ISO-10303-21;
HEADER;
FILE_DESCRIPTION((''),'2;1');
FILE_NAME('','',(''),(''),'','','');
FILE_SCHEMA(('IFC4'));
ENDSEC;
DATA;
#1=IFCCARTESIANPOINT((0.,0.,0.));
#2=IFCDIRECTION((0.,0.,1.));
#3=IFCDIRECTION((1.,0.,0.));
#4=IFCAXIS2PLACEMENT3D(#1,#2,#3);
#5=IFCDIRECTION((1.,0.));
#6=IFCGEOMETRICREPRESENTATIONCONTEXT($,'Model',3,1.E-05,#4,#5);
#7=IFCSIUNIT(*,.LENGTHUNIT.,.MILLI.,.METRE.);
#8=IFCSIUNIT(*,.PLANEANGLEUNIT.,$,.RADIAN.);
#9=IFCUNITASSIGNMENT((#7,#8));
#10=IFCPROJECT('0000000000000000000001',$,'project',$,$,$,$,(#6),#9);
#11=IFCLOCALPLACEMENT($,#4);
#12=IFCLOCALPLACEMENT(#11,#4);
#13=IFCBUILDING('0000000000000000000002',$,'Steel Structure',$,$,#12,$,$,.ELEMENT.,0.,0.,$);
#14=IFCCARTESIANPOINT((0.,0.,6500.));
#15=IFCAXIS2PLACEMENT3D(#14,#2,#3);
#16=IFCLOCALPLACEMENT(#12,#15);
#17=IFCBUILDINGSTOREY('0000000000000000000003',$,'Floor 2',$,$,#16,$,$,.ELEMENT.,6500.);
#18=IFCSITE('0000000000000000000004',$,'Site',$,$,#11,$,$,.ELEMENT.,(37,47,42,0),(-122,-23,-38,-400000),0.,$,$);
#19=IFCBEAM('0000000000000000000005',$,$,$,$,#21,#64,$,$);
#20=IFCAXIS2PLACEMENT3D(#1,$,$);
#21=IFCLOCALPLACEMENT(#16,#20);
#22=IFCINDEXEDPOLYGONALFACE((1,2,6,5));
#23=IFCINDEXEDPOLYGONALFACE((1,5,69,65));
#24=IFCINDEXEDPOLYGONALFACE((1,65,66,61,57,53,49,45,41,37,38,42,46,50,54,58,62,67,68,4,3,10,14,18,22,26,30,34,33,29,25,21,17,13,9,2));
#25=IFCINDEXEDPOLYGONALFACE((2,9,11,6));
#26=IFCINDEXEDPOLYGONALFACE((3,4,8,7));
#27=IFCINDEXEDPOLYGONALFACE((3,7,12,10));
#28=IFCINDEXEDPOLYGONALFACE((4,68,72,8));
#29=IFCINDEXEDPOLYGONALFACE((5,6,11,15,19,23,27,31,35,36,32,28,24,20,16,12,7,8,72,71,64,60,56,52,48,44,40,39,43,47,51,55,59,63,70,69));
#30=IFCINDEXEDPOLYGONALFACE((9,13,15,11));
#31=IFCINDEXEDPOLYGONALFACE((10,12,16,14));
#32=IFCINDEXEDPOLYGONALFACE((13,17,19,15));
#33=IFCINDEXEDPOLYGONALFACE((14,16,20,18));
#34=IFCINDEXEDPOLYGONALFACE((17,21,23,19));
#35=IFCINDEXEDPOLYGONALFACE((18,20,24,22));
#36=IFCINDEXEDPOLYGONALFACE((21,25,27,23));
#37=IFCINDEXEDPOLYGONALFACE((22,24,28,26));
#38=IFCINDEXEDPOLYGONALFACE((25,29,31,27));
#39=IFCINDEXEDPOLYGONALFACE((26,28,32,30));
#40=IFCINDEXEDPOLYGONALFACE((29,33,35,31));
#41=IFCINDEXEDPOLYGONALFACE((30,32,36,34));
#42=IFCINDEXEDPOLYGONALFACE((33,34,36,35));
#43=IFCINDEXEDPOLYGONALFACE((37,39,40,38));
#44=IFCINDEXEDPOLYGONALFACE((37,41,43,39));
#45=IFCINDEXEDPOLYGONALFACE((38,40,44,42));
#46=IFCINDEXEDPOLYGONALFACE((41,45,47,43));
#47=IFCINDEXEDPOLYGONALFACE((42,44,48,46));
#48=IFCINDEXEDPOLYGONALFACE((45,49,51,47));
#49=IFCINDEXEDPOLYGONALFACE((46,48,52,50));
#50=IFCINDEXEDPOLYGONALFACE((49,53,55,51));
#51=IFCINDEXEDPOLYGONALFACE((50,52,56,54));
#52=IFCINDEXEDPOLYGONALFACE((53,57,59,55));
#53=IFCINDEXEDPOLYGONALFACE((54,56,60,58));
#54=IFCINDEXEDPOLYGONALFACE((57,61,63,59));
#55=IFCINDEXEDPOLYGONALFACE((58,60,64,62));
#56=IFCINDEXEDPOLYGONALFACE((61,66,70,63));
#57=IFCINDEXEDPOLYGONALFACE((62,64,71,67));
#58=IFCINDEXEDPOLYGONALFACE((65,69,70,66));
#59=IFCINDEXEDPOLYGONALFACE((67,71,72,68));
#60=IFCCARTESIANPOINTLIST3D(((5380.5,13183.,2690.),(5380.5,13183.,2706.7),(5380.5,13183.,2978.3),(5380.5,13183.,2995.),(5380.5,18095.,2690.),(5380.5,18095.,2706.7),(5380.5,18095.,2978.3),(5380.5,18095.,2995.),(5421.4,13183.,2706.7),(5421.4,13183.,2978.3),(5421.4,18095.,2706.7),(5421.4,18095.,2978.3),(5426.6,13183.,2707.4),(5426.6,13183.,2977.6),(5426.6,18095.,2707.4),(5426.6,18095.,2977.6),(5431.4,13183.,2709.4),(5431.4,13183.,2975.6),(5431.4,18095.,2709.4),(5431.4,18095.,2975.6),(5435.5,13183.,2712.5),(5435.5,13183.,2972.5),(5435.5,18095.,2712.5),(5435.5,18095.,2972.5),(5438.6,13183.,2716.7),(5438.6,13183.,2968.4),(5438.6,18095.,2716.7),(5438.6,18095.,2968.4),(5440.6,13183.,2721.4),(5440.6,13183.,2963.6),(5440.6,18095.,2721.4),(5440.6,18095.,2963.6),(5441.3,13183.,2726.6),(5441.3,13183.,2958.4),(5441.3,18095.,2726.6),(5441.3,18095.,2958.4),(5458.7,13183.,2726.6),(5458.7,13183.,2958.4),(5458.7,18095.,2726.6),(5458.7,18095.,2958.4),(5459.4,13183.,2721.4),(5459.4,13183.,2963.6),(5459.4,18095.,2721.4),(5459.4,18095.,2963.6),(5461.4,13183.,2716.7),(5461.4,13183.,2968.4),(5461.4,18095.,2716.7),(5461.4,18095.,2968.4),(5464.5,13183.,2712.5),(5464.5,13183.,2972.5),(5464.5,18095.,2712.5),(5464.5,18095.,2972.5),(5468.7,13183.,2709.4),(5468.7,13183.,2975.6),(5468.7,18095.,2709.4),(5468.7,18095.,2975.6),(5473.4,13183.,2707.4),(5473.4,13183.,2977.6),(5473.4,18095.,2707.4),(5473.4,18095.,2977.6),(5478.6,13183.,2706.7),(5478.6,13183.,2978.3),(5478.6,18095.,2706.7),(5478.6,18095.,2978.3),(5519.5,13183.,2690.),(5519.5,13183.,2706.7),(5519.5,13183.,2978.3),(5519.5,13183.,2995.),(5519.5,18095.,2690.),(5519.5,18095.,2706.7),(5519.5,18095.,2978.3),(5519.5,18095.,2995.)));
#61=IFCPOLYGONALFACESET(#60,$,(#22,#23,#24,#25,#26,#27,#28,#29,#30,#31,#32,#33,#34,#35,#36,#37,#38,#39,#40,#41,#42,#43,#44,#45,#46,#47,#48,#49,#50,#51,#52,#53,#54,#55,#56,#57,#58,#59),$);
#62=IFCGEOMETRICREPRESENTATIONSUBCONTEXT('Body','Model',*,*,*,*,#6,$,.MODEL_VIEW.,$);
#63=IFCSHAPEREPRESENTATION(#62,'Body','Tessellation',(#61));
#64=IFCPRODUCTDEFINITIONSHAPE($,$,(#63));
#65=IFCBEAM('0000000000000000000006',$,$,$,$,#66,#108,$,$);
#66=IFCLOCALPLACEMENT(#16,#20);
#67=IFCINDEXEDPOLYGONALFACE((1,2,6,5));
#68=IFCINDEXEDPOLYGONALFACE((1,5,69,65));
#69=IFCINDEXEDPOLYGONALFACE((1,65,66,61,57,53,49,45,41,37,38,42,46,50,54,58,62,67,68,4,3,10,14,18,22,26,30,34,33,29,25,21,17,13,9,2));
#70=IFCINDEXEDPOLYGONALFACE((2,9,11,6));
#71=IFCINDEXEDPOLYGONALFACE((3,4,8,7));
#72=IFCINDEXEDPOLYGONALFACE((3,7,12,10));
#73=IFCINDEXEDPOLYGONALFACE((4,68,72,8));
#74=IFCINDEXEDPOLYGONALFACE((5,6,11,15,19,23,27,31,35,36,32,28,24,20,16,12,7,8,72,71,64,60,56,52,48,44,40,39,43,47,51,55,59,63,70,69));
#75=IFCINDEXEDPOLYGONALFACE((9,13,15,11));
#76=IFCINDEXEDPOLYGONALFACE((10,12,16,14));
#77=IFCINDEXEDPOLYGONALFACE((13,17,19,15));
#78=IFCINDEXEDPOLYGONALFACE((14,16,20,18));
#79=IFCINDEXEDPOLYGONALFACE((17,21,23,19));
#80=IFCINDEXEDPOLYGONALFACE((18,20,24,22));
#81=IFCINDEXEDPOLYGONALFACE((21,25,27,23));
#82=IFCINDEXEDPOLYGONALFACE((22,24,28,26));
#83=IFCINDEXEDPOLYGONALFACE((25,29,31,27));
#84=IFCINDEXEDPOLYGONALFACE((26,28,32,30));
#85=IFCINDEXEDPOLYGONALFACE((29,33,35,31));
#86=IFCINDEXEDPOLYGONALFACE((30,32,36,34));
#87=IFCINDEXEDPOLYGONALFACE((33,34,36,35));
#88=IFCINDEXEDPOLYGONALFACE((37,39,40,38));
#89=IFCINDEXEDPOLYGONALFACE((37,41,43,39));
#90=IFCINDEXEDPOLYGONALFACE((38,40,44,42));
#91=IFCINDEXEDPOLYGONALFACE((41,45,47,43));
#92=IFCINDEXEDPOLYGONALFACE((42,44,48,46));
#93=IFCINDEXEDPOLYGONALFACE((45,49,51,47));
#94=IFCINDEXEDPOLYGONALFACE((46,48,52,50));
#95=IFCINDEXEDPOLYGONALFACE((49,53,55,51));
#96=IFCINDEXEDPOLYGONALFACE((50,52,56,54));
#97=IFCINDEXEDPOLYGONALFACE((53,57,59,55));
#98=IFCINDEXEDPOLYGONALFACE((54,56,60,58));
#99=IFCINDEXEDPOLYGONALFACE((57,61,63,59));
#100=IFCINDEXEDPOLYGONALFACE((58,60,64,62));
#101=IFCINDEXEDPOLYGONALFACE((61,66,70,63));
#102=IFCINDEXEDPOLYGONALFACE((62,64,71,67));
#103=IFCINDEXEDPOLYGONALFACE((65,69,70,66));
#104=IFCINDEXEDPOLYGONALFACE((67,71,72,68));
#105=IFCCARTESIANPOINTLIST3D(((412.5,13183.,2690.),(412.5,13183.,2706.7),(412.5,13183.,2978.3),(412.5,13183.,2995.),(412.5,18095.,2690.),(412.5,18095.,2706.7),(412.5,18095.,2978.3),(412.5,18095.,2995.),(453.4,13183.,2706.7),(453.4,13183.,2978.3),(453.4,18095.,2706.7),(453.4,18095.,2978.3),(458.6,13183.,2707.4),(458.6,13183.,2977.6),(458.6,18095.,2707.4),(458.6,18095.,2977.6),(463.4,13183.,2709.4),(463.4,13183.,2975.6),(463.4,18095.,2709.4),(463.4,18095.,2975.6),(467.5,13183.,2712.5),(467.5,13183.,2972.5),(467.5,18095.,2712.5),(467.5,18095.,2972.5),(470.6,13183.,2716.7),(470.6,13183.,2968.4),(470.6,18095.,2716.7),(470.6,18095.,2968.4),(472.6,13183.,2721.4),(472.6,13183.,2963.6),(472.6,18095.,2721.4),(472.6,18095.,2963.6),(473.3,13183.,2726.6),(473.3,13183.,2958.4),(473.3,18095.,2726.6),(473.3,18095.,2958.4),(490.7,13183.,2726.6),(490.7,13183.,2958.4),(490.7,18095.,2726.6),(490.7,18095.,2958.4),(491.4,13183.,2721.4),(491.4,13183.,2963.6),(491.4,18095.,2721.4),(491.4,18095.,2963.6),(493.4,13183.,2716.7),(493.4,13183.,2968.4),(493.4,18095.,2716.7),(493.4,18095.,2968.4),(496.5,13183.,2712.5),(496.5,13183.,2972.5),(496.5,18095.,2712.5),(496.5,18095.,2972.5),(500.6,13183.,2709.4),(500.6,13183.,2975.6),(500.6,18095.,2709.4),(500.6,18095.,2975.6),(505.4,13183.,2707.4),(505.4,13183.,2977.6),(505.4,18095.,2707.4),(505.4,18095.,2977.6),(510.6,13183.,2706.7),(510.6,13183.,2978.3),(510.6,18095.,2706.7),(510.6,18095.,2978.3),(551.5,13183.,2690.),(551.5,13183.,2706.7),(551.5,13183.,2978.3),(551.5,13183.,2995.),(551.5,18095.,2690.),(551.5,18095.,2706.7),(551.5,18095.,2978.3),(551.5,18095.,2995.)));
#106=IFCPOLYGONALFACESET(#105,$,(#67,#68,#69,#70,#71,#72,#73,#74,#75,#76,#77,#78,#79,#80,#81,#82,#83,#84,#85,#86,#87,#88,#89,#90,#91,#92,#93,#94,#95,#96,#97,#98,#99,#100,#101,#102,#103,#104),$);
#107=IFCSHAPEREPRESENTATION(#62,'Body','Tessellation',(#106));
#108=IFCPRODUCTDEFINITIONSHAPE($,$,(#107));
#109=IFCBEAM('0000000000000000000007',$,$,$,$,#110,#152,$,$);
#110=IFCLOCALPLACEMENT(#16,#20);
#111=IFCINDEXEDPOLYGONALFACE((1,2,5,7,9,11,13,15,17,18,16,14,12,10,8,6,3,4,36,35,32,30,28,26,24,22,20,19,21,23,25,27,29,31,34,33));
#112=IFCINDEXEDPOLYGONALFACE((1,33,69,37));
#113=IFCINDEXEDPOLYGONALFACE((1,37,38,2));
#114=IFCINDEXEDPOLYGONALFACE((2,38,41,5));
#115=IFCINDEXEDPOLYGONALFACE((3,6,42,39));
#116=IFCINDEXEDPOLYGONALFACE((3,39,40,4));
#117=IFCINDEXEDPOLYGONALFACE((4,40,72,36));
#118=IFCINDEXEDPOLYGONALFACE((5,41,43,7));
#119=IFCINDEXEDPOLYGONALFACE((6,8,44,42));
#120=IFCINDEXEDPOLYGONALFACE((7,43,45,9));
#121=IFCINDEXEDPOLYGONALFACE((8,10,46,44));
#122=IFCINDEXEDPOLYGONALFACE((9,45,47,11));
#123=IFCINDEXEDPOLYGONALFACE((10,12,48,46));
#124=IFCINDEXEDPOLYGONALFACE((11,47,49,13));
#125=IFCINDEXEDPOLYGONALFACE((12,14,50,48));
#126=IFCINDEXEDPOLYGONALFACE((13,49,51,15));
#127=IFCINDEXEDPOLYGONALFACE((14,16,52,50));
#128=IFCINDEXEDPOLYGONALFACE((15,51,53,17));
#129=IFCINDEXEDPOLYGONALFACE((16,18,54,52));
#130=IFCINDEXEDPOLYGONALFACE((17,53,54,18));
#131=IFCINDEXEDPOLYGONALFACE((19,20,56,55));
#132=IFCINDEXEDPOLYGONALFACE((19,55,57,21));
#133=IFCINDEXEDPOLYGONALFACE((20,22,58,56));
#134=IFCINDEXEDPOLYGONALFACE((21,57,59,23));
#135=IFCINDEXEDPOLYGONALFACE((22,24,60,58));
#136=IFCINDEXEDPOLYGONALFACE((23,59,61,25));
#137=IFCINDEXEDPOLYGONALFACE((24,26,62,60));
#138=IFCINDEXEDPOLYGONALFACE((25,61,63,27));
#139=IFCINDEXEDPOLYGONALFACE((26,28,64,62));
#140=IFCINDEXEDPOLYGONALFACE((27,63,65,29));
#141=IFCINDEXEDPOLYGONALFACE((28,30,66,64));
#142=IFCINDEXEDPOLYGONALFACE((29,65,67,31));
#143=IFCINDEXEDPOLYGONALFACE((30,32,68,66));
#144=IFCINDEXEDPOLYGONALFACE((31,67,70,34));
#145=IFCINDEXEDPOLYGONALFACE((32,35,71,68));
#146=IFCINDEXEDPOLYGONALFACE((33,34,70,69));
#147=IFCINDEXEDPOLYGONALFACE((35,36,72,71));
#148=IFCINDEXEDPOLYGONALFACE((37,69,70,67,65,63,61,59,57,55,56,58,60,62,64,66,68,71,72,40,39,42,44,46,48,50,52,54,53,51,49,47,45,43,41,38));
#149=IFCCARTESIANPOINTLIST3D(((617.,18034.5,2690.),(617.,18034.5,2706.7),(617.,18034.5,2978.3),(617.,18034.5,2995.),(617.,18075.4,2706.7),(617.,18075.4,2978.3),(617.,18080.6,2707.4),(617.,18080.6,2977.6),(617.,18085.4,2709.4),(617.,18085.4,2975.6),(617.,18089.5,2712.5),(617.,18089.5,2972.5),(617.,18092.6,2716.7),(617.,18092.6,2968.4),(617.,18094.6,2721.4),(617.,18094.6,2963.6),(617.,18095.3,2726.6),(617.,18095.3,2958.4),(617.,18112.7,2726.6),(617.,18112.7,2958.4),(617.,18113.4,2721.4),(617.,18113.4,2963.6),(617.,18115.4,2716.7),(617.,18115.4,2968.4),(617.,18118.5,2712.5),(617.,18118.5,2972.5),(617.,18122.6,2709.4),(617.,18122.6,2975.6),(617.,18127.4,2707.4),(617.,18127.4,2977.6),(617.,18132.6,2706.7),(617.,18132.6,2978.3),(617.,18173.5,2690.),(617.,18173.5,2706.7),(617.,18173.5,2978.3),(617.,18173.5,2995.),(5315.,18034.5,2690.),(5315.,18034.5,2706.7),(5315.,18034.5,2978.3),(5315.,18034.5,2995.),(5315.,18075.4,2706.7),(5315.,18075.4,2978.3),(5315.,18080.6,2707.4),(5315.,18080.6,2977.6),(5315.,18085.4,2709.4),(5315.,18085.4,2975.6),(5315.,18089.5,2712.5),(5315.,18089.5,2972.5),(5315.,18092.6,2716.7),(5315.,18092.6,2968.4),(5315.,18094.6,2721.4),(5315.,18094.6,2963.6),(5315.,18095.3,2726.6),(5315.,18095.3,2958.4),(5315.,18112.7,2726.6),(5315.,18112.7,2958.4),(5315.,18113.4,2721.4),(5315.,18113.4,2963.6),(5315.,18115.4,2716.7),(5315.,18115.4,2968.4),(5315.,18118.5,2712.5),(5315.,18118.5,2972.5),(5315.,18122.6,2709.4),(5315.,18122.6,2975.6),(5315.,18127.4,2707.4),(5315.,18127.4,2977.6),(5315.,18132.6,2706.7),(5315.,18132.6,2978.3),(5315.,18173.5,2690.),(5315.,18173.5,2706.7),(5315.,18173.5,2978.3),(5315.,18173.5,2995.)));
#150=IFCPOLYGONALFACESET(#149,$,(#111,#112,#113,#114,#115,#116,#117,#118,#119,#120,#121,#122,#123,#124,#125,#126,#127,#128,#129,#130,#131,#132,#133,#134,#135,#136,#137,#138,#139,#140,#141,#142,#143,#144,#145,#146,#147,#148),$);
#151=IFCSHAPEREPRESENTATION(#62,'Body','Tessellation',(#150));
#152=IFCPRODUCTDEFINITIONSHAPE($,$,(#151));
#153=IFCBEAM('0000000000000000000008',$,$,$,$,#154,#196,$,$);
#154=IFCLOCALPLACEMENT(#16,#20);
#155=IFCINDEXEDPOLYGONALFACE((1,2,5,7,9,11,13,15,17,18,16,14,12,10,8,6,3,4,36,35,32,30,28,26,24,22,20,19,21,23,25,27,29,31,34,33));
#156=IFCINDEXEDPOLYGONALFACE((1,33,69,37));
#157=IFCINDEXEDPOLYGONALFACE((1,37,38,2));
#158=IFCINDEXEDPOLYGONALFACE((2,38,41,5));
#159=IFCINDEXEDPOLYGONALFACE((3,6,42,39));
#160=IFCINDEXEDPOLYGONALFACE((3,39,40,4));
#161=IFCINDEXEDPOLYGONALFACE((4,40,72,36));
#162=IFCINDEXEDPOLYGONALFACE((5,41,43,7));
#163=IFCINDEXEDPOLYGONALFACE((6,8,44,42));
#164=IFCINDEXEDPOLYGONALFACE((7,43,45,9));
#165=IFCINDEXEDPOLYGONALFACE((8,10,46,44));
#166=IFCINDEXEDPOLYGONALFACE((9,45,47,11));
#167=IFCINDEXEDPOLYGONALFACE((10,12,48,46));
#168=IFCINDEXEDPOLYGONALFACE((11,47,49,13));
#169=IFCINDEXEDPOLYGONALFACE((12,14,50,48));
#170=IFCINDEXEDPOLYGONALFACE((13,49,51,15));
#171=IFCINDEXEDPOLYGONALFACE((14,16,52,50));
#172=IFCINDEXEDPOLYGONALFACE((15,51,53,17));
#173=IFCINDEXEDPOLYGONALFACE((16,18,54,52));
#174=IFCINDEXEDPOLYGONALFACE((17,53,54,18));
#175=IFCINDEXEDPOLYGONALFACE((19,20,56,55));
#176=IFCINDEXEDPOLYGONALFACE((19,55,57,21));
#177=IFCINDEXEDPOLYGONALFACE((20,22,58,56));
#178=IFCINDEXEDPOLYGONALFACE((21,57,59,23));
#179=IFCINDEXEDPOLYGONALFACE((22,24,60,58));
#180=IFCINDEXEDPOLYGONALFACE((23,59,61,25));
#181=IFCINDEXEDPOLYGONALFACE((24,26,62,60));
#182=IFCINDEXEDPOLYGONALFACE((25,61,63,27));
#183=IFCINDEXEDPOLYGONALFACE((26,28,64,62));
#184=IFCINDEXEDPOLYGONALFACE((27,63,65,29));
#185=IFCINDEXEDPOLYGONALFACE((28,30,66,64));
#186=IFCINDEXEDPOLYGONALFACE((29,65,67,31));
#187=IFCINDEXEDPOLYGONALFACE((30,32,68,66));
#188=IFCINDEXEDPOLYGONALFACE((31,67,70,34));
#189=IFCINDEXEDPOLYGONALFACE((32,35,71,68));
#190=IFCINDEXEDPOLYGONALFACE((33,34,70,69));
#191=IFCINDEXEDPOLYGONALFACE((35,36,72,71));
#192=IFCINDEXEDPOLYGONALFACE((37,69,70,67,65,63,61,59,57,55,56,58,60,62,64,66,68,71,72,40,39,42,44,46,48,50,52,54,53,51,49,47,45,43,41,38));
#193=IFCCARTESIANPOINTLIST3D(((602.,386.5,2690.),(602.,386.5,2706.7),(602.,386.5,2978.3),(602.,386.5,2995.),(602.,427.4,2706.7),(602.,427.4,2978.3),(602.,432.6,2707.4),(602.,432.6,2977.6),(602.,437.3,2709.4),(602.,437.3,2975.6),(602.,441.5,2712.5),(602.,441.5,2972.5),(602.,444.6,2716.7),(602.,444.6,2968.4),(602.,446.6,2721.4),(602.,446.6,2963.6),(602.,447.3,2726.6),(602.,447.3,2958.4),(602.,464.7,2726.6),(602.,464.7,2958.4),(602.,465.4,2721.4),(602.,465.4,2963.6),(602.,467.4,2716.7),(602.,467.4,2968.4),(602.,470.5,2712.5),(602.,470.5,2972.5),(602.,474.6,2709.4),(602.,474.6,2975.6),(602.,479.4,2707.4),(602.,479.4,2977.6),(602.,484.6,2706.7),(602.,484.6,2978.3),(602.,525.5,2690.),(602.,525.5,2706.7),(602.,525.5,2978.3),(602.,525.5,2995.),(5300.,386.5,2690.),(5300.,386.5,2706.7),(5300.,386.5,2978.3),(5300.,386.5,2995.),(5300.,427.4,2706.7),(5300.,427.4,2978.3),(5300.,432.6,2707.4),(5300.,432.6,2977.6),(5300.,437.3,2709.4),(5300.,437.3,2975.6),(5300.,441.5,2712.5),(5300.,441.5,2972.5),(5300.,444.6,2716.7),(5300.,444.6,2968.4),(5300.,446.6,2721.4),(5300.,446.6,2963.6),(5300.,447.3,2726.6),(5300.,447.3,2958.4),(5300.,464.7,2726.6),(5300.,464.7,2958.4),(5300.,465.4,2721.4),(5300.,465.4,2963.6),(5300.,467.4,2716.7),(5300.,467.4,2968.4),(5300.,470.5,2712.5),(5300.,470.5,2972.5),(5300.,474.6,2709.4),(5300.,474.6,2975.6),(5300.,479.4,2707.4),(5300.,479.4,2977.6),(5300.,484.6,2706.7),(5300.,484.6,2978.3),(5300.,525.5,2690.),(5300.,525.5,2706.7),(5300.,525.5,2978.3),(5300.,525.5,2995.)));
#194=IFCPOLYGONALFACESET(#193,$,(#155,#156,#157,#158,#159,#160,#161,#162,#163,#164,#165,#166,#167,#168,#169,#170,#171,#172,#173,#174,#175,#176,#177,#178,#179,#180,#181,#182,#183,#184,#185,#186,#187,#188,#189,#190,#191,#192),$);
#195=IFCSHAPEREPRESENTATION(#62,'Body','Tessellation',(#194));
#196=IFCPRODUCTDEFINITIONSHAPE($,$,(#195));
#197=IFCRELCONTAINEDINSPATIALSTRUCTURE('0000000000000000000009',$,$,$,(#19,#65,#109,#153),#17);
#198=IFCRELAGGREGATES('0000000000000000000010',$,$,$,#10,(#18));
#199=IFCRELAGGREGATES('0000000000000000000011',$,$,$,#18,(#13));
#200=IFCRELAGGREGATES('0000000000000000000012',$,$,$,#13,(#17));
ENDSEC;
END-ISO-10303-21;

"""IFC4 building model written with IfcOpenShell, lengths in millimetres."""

from ifc_helpers import new_model, si_unit, direction, frame, origin_with_axes, origin_2d_with_axis, place, context, subcontext, project, spatial, i_section, extrude, element, save


model = new_model("IFC4")

# Units and contexts
model_context = context("Model", 3, precision=1e-05, world=origin_with_axes(), true_north=direction((1.0, 0.0)))
body_context = subcontext(model_context, "Body", "Model", "MODEL_VIEW")
ifc_project = project(units=[si_unit("LENGTHUNIT", "METRE", prefix="MILLI"), si_unit("PLANEANGLEUNIT", "RADIAN")], contexts=[model_context])

# Site, building, storey
site_placement = place(None, origin_with_axes())
site = spatial("IfcSite", under=ifc_project, at=site_placement, Name="Site", CompositionType="ELEMENT", RefLatitude=(37, 47, 42, 0), RefLongitude=(-122, -23, -38, -400000), RefElevation=0.0)
building_placement = place(site_placement, origin_with_axes())
building = spatial("IfcBuilding", under=site, at=building_placement, Name="Steel Structure", CompositionType="ELEMENT", ElevationOfRefHeight=0.0, ElevationOfTerrain=0.0)
storey_placement = place(building_placement, frame((0.0, 0.0, 6500.0), z_axis=(0.0, 0.0, 1.0), x_axis=(1.0, 0.0, 0.0)))
storey = spatial("IfcBuildingStorey", under=building, at=storey_placement, Name="Floor 2", CompositionType="ELEMENT", Elevation=6500.0)

# Beams
for number, where, z_axis, x_axis in (
    (1, (5450.0, 18095.0, 2690.0), (0.0, -1.0, 0.0), (1.0, 0.0, 0.0)),
    (2, (482.0, 13183.0, 2690.0), (0.0, 1.0, 0.0), (-1.0, 0.0, 0.0)),
):
    element("IfcBeam", number, at=place(storey_placement, frame(where, z_axis=z_axis, x_axis=x_axis)), inside=storey, context=body_context, shape_type="SweptSolid", body=[
        extrude(i_section(OverallWidth=139.0, OverallDepth=305.0, WebThickness=17.4, FlangeThickness=16.7, FilletRadius=19.9, at=origin_2d_with_axis()), frame((0.0, 152.5, 0.0), z_axis=(0.0, 0.0, 1.0), x_axis=(1.0, 0.0, 0.0)), (0.0, 0.0, 1.0), 4912.0),
    ])
beam_1_placement = place(storey_placement, frame((5315.0, 18104.0, 2690.0), z_axis=(-1.0, 0.0, 0.0), x_axis=(0.0, -1.0, 0.0)))
element("IfcBeam", 3, at=beam_1_placement, inside=storey, context=body_context, shape_type="SweptSolid", body=[
    extrude(i_section(OverallWidth=139.0, OverallDepth=305.0, WebThickness=17.4, FlangeThickness=16.7, FilletRadius=19.9, at=origin_2d_with_axis()), frame((0.0, 152.5, 0.0), z_axis=(0.0, 0.0, 1.0), x_axis=(1.0, 0.0, 0.0)), (0.0, 0.0, 1.0), 4698.0),
])
beam_2_placement = place(storey_placement, frame((602.0, 456.0, 2690.0), z_axis=(1.0, 0.0, 0.0), x_axis=(0.0, 1.0, 0.0)))
element("IfcBeam", 4, at=beam_2_placement, inside=storey, context=body_context, shape_type="SweptSolid", body=[
    extrude(i_section(OverallWidth=139.0, OverallDepth=305.0, WebThickness=17.4, FlangeThickness=16.7, FilletRadius=19.9, at=origin_2d_with_axis()), frame((0.0, 152.5, 0.0), z_axis=(0.0, 0.0, 1.0), x_axis=(1.0, 0.0, 0.0)), (0.0, 0.0, 1.0), 4698.0),
])

save(model, "model.ifc")
